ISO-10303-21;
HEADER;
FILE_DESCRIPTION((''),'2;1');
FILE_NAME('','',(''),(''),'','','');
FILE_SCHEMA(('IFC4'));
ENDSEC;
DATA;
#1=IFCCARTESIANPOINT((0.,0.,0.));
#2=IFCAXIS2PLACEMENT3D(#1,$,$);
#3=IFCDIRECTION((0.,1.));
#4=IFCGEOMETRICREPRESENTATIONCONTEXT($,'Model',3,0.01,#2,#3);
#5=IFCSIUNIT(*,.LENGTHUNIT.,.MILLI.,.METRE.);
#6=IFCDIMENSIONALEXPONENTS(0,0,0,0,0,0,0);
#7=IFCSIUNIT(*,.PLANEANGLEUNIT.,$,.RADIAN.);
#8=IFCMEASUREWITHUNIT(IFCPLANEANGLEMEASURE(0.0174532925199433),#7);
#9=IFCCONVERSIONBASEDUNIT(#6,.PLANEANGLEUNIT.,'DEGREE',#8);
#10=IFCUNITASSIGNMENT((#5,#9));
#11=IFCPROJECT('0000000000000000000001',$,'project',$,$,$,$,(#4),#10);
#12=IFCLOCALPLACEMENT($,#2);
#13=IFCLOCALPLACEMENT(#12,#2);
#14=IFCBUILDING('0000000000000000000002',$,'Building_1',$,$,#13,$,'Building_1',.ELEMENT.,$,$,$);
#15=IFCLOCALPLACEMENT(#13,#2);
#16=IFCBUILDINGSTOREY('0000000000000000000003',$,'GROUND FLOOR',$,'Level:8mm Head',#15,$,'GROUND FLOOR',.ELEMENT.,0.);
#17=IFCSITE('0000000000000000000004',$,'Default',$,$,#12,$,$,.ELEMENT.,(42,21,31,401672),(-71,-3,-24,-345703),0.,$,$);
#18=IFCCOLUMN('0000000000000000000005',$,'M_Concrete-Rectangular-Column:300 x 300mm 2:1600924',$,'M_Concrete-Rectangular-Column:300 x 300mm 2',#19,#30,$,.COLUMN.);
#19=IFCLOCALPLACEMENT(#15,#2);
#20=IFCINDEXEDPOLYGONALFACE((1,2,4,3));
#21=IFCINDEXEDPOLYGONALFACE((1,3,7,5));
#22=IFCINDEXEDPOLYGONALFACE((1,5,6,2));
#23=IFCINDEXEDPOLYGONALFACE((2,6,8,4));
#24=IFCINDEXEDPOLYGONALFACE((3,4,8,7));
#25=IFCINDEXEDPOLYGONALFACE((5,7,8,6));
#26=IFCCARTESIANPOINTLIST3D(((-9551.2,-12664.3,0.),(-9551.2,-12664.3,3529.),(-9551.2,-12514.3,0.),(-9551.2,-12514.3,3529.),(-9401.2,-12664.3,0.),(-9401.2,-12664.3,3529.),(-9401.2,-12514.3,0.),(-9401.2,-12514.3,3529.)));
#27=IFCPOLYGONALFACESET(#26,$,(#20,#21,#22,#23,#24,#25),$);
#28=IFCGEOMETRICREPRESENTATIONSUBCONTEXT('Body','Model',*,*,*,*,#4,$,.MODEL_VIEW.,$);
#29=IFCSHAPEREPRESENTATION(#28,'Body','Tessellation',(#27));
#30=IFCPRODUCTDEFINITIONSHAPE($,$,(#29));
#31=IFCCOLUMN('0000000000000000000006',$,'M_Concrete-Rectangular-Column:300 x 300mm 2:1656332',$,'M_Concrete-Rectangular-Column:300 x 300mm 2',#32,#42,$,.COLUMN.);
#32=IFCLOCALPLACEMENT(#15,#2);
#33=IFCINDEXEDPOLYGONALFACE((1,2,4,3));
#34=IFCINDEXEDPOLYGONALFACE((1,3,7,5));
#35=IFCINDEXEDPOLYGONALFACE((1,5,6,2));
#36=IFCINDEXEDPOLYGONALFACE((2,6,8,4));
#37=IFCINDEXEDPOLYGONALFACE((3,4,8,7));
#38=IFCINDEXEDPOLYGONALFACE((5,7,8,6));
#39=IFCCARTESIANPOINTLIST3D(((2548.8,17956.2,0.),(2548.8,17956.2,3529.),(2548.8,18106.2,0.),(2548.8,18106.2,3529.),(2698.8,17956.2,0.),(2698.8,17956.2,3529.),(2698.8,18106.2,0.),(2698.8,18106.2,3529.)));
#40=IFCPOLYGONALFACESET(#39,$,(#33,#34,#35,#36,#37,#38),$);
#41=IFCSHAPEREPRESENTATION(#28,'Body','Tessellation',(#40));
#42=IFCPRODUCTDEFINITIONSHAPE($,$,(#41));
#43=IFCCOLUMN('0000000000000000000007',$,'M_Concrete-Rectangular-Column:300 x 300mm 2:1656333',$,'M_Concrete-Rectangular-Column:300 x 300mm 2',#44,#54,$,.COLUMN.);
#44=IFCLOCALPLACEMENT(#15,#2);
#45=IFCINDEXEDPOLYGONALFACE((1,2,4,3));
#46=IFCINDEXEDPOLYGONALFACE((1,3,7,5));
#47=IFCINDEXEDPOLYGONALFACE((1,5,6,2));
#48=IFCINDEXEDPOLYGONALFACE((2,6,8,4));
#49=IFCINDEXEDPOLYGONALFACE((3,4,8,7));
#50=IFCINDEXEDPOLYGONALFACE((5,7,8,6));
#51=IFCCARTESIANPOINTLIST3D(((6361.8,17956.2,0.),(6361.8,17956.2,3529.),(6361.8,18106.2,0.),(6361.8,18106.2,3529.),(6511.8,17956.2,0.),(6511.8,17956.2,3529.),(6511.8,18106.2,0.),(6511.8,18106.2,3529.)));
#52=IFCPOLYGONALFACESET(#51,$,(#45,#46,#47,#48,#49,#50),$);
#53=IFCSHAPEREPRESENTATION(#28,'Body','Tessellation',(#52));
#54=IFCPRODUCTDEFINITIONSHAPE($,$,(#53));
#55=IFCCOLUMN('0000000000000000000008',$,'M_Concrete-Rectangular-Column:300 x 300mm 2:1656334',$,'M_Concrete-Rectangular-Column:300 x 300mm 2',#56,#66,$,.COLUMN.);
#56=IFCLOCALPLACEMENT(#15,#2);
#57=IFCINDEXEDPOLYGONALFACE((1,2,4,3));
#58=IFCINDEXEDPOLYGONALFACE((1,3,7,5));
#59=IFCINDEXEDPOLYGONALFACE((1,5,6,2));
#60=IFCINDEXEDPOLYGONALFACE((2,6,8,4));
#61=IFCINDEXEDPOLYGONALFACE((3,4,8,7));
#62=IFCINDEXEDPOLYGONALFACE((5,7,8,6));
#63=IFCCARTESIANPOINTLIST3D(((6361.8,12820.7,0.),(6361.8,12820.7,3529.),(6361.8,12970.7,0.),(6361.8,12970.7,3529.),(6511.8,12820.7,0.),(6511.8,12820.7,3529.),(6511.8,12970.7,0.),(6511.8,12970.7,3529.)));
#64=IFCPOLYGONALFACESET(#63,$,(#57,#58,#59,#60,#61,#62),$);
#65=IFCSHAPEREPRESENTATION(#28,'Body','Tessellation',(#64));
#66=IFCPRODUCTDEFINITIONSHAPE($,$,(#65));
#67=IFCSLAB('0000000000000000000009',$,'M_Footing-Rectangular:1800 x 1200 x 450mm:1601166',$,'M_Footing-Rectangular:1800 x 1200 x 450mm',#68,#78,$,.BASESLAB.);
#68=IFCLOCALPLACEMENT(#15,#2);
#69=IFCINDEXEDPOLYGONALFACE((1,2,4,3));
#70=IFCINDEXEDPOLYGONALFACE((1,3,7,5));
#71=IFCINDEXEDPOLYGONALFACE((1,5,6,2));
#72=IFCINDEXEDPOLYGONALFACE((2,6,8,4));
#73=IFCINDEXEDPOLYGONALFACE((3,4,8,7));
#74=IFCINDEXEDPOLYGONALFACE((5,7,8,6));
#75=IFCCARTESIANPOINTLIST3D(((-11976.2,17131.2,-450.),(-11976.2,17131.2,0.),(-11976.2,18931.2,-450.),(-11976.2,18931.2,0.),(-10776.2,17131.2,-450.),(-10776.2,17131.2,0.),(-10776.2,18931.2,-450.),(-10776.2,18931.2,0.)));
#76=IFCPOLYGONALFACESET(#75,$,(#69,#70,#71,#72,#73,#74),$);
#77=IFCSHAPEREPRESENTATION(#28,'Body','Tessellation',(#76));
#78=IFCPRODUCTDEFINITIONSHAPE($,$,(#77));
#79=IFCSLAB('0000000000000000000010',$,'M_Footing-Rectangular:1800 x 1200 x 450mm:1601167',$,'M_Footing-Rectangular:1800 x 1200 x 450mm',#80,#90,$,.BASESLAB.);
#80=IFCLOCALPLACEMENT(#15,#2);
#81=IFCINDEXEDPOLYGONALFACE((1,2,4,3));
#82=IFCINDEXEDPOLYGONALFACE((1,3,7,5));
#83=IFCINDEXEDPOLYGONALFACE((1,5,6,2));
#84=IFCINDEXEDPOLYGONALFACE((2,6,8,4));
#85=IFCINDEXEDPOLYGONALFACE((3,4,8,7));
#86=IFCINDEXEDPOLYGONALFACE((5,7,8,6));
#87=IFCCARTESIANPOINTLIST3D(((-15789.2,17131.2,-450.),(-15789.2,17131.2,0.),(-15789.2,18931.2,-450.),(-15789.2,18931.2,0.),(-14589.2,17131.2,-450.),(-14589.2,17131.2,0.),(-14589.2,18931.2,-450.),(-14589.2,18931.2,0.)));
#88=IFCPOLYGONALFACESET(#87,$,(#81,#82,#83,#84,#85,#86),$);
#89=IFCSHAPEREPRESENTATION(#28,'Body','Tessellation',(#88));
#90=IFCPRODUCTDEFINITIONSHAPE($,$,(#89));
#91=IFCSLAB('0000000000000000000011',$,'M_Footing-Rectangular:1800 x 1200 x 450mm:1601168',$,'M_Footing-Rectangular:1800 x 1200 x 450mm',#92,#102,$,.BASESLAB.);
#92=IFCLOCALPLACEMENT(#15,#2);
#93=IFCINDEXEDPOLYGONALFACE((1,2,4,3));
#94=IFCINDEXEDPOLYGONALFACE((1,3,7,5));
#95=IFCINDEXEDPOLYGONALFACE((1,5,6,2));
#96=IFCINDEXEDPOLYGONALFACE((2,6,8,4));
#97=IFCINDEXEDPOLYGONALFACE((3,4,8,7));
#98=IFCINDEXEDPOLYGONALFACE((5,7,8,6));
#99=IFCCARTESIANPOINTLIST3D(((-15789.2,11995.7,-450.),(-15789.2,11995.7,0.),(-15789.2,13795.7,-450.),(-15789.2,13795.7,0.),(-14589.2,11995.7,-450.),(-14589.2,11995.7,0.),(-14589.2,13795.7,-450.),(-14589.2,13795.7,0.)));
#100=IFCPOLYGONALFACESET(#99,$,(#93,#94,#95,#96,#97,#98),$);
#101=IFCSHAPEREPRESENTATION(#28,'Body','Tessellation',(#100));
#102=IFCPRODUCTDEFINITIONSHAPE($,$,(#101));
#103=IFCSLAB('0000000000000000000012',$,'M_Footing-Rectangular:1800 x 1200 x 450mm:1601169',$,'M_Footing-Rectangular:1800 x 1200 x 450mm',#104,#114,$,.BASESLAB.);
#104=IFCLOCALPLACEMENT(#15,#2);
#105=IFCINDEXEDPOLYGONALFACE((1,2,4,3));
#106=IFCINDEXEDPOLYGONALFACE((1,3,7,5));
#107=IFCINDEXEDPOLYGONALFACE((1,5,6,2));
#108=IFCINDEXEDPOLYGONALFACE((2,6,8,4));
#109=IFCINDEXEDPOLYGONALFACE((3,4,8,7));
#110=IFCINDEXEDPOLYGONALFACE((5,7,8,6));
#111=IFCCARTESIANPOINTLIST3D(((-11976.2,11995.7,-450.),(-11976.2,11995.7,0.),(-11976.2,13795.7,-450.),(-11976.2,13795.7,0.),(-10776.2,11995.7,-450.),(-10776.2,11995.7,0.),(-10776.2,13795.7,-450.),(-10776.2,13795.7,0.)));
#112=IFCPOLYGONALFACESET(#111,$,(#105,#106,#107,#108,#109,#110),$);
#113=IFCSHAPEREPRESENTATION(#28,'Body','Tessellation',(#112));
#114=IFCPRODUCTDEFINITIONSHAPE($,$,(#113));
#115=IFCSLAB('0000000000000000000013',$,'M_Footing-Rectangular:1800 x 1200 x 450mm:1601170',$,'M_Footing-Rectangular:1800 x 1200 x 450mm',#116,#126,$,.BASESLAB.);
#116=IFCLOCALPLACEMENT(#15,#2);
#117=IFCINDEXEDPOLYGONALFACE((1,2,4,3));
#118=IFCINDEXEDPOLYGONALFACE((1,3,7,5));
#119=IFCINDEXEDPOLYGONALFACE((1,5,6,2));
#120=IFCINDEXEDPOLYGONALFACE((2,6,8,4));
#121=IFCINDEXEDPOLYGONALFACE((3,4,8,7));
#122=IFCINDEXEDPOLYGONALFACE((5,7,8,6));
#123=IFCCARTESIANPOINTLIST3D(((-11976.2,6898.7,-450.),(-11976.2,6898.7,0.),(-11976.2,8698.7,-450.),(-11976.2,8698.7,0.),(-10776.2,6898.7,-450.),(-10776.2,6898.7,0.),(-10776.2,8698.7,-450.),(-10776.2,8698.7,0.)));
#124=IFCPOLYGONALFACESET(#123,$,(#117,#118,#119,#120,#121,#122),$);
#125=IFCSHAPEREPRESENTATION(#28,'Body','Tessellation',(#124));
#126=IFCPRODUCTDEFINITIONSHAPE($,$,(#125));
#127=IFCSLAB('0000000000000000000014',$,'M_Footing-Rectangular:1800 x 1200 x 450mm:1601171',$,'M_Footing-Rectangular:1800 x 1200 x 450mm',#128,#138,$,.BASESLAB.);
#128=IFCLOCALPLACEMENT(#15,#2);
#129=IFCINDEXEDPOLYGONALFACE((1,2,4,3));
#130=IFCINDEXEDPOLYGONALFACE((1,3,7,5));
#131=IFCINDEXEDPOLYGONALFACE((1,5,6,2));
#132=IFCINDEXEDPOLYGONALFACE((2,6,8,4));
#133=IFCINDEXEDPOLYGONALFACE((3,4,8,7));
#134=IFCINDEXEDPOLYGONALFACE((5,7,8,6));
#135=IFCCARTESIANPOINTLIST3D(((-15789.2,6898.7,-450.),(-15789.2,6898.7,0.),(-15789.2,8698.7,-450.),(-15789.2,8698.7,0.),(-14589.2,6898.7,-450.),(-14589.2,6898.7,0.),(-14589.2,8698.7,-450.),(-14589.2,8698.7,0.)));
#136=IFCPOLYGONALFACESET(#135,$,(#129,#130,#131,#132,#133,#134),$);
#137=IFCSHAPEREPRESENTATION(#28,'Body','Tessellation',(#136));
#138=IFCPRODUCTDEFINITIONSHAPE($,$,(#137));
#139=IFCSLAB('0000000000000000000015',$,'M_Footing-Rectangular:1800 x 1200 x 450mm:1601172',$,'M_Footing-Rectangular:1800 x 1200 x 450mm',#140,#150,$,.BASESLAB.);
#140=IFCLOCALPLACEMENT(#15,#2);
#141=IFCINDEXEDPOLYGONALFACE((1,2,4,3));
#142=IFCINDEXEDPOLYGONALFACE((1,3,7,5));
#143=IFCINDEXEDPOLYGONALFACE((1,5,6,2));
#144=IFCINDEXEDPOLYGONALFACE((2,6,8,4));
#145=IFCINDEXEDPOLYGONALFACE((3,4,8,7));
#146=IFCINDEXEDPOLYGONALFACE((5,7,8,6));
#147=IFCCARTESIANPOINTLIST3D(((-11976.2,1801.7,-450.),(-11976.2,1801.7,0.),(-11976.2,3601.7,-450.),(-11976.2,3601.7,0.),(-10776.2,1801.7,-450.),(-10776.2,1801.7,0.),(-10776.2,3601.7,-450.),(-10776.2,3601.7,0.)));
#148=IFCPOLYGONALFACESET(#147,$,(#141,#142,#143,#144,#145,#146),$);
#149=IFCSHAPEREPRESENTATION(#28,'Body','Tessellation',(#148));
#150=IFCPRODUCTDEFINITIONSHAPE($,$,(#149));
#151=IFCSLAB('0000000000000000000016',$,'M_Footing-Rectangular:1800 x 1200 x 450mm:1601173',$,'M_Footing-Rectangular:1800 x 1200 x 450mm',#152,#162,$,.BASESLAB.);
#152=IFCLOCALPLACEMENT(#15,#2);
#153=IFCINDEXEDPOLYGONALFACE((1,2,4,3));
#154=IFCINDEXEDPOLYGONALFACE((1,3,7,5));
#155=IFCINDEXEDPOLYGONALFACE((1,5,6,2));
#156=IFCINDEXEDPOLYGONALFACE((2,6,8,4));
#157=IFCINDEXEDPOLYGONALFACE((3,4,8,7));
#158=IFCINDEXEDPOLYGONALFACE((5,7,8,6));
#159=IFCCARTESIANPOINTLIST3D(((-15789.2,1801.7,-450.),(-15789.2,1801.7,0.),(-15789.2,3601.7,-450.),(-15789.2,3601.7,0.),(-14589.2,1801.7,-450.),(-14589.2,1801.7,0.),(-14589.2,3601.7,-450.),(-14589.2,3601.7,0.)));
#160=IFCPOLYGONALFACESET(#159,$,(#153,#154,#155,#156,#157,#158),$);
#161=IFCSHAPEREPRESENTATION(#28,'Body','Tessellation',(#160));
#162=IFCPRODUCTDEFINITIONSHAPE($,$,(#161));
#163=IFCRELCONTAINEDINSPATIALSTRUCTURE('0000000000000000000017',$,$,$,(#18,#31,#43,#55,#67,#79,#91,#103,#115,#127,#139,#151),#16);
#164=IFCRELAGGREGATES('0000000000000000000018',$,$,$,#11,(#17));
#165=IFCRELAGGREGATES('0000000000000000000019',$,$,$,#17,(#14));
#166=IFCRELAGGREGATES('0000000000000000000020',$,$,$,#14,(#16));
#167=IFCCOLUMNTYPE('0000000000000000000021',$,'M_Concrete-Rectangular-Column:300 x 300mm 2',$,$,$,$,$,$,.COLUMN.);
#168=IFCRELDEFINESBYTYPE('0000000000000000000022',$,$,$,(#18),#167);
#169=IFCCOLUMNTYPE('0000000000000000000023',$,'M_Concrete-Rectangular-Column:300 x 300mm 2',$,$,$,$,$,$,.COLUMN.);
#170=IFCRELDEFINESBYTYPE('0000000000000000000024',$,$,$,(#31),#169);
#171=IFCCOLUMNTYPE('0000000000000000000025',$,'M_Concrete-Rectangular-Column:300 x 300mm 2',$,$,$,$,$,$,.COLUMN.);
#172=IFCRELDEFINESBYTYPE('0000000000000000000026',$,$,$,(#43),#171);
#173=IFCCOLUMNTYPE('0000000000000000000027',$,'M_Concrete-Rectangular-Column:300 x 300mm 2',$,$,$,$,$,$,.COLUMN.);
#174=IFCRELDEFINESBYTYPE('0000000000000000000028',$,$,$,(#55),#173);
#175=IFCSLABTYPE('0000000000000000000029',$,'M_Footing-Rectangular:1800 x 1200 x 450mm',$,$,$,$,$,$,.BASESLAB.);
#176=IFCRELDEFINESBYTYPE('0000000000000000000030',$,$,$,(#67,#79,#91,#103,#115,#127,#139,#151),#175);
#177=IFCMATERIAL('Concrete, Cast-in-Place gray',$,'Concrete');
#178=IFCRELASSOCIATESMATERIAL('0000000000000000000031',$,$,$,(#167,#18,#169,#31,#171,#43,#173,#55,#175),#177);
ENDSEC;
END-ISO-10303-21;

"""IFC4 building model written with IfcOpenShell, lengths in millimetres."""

from ifc_helpers import new_model, entity, si_unit, converted_unit, direction, frame, origin, place, context, subcontext, project, spatial, indexed_curve, outline, extrude, source, transform, mapped, material, type_object, type_shapes, element, save


model = new_model("IFC4")

# Units and contexts
model_context = context("Model", 3, precision=0.01, world=origin(), true_north=direction((0.0, 1.0)))
body_context = subcontext(model_context, "Body", "Model", "MODEL_VIEW")
ifc_project = project(units=[si_unit("LENGTHUNIT", "METRE", prefix="MILLI"), converted_unit("PLANEANGLEUNIT", "DEGREE", entity("IfcPlaneAngleMeasure", 0.0174532925199433), si_unit("PLANEANGLEUNIT", "RADIAN"), dimensions=[0, 0, 0, 0, 0, 0, 0])], contexts=[model_context])

# Site, building, storey
site_placement = place(None, origin())
site = spatial("IfcSite", under=ifc_project, at=site_placement, Name="Default", CompositionType="ELEMENT", RefLatitude=(42, 21, 31, 401672), RefLongitude=(-71, -3, -24, -345703), RefElevation=0.0)
building_placement = place(site_placement, origin())
building = spatial("IfcBuilding", under=site, at=building_placement, Name="Building_1", LongName="Building_1", CompositionType="ELEMENT")
storey_placement = place(building_placement, origin())
storey = spatial("IfcBuildingStorey", under=building, at=storey_placement, Name="GROUND FLOOR", ObjectType="Level:8mm Head", LongName="GROUND FLOOR", CompositionType="ELEMENT", Elevation=0.0)

# Columns
ifc_material_1 = material(Name="Concrete, Cast-in-Place gray", Category="Concrete")
column_type_1 = type_object("IfcColumnType", Name="M_Concrete-Rectangular-Column:300 x 300mm 2", PredefinedType="COLUMN", material=ifc_material_1)
shared_shape_1 = source(origin(), body_context, "Body", "SweptSolid", [
    extrude(outline(indexed_curve([(-75.0, -75.0), (75.0, -75.0), (75.0, 75.0), (-75.0, 75.0), (-75.0, -75.0)], self_intersect=False)), frame((-9476.2, -12589.3, 0.0), z_axis=(0.0, 0.0, 1.0), x_axis=(-1.0, 0.0, 0.0)), (0.0, 0.0, 1.0), 3529.0),
])
type_shapes(column_type_1, [shared_shape_1])
column_1_placement = place(storey_placement, origin())
element("IfcColumn", 1, at=column_1_placement, inside=storey, type_object=column_type_1, material=ifc_material_1, Name="M_Concrete-Rectangular-Column:300 x 300mm 2:1600924", ObjectType="M_Concrete-Rectangular-Column:300 x 300mm 2", PredefinedType="COLUMN", context=body_context, shape_type="MappedRepresentation", body=[
    mapped(shared_shape_1, transform((0.0, 0.0, 0.0), scale=1.0)),
])
column_type_2 = type_object("IfcColumnType", Name="M_Concrete-Rectangular-Column:300 x 300mm 2", PredefinedType="COLUMN", material=ifc_material_1)
shared_shape_2 = source(origin(), body_context, "Body", "SweptSolid", [
    extrude(outline(indexed_curve([(-75.0, -75.0), (75.0, -75.0), (75.0, 75.0), (-75.0, 75.0), (-75.0, -75.0)], self_intersect=False)), frame((2623.8, 18031.2, 0.0)), (0.0, 0.0, 1.0), 3529.0),
])
type_shapes(column_type_2, [shared_shape_2])
column_2_placement = place(storey_placement, origin())
element("IfcColumn", 2, at=column_2_placement, inside=storey, type_object=column_type_2, material=ifc_material_1, Name="M_Concrete-Rectangular-Column:300 x 300mm 2:1656332", ObjectType="M_Concrete-Rectangular-Column:300 x 300mm 2", PredefinedType="COLUMN", context=body_context, shape_type="MappedRepresentation", body=[
    mapped(shared_shape_2, transform((0.0, 0.0, 0.0), scale=1.0)),
])
column_type_3 = type_object("IfcColumnType", Name="M_Concrete-Rectangular-Column:300 x 300mm 2", PredefinedType="COLUMN", material=ifc_material_1)
shared_shape_3 = source(origin(), body_context, "Body", "SweptSolid", [
    extrude(outline(indexed_curve([(-75.0, -75.0), (75.0, -75.0), (75.0, 75.0), (-75.0, 75.0), (-75.0, -75.0)], self_intersect=False)), frame((6436.8, 18031.2, 0.0)), (0.0, 0.0, 1.0), 3529.0),
])
type_shapes(column_type_3, [shared_shape_3])
column_3_placement = place(storey_placement, origin())
element("IfcColumn", 3, at=column_3_placement, inside=storey, type_object=column_type_3, material=ifc_material_1, Name="M_Concrete-Rectangular-Column:300 x 300mm 2:1656333", ObjectType="M_Concrete-Rectangular-Column:300 x 300mm 2", PredefinedType="COLUMN", context=body_context, shape_type="MappedRepresentation", body=[
    mapped(shared_shape_3, transform((0.0, 0.0, 0.0), scale=1.0)),
])
column_type_4 = type_object("IfcColumnType", Name="M_Concrete-Rectangular-Column:300 x 300mm 2", PredefinedType="COLUMN", material=ifc_material_1)
shared_shape_4 = source(origin(), body_context, "Body", "SweptSolid", [
    extrude(outline(indexed_curve([(-75.0, -75.0), (75.0, -75.0), (75.0, 75.0), (-75.0, 75.0), (-75.0, -75.0)], self_intersect=False)), frame((6436.8, 12895.7, 0.0)), (0.0, 0.0, 1.0), 3529.0),
])
type_shapes(column_type_4, [shared_shape_4])
column_4_placement = place(storey_placement, origin())
element("IfcColumn", 4, at=column_4_placement, inside=storey, type_object=column_type_4, material=ifc_material_1, Name="M_Concrete-Rectangular-Column:300 x 300mm 2:1656334", ObjectType="M_Concrete-Rectangular-Column:300 x 300mm 2", PredefinedType="COLUMN", context=body_context, shape_type="MappedRepresentation", body=[
    mapped(shared_shape_4, transform((0.0, 0.0, 0.0), scale=1.0)),
])

# Slabs
slab_type_1 = type_object("IfcSlabType", Name="M_Footing-Rectangular:1800 x 1200 x 450mm", PredefinedType="BASESLAB", material=ifc_material_1)
slab_1_placement = place(storey_placement, origin())
element("IfcSlab", 5, at=slab_1_placement, inside=storey, type_object=slab_type_1, Name="M_Footing-Rectangular:1800 x 1200 x 450mm:1601166", ObjectType="M_Footing-Rectangular:1800 x 1200 x 450mm", PredefinedType="BASESLAB", context=body_context, shape_type="SweptSolid", body=[
    extrude(outline(indexed_curve([(-600.0, -900.0), (600.0, -900.0), (600.0, 900.0), (-600.0, 900.0), (-600.0, -900.0)], self_intersect=False)), frame((-11376.2, 18031.2, -450.0), z_axis=(0.0, 0.0, 1.0), x_axis=(-1.0, 0.0, 0.0)), (0.0, 0.0, 1.0), 450.0),
])
slab_2_placement = place(storey_placement, origin())
element("IfcSlab", 6, at=slab_2_placement, inside=storey, type_object=slab_type_1, Name="M_Footing-Rectangular:1800 x 1200 x 450mm:1601167", ObjectType="M_Footing-Rectangular:1800 x 1200 x 450mm", PredefinedType="BASESLAB", context=body_context, shape_type="SweptSolid", body=[
    extrude(outline(indexed_curve([(-600.0, -900.0), (600.0, -900.0), (600.0, 900.0), (-600.0, 900.0), (-600.0, -900.0)], self_intersect=False)), frame((-15189.2, 18031.2, -450.0), z_axis=(0.0, 0.0, 1.0), x_axis=(-1.0, 0.0, 0.0)), (0.0, 0.0, 1.0), 450.0),
])
slab_3_placement = place(storey_placement, origin())
element("IfcSlab", 7, at=slab_3_placement, inside=storey, type_object=slab_type_1, Name="M_Footing-Rectangular:1800 x 1200 x 450mm:1601168", ObjectType="M_Footing-Rectangular:1800 x 1200 x 450mm", PredefinedType="BASESLAB", context=body_context, shape_type="SweptSolid", body=[
    extrude(outline(indexed_curve([(-600.0, -900.0), (600.0, -900.0), (600.0, 900.0), (-600.0, 900.0), (-600.0, -900.0)], self_intersect=False)), frame((-15189.2, 12895.7, -450.0), z_axis=(0.0, 0.0, 1.0), x_axis=(-1.0, 0.0, 0.0)), (0.0, 0.0, 1.0), 450.0),
])
slab_4_placement = place(storey_placement, origin())
element("IfcSlab", 8, at=slab_4_placement, inside=storey, type_object=slab_type_1, Name="M_Footing-Rectangular:1800 x 1200 x 450mm:1601169", ObjectType="M_Footing-Rectangular:1800 x 1200 x 450mm", PredefinedType="BASESLAB", context=body_context, shape_type="SweptSolid", body=[
    extrude(outline(indexed_curve([(-600.0, -900.0), (600.0, -900.0), (600.0, 900.0), (-600.0, 900.0), (-600.0, -900.0)], self_intersect=False)), frame((-11376.2, 12895.7, -450.0), z_axis=(0.0, 0.0, 1.0), x_axis=(-1.0, 0.0, 0.0)), (0.0, 0.0, 1.0), 450.0),
])
slab_5_placement = place(storey_placement, origin())
element("IfcSlab", 9, at=slab_5_placement, inside=storey, type_object=slab_type_1, Name="M_Footing-Rectangular:1800 x 1200 x 450mm:1601170", ObjectType="M_Footing-Rectangular:1800 x 1200 x 450mm", PredefinedType="BASESLAB", context=body_context, shape_type="SweptSolid", body=[
    extrude(outline(indexed_curve([(-600.0, -900.0), (600.0, -900.0), (600.0, 900.0), (-600.0, 900.0), (-600.0, -900.0)], self_intersect=False)), frame((-11376.2, 7798.7, -450.0), z_axis=(0.0, 0.0, 1.0), x_axis=(-1.0, 0.0, 0.0)), (0.0, 0.0, 1.0), 450.0),
])
slab_6_placement = place(storey_placement, origin())
element("IfcSlab", 10, at=slab_6_placement, inside=storey, type_object=slab_type_1, Name="M_Footing-Rectangular:1800 x 1200 x 450mm:1601171", ObjectType="M_Footing-Rectangular:1800 x 1200 x 450mm", PredefinedType="BASESLAB", context=body_context, shape_type="SweptSolid", body=[
    extrude(outline(indexed_curve([(-600.0, -900.0), (600.0, -900.0), (600.0, 900.0), (-600.0, 900.0), (-600.0, -900.0)], self_intersect=False)), frame((-15189.2, 7798.7, -450.0), z_axis=(0.0, 0.0, 1.0), x_axis=(-1.0, 0.0, 0.0)), (0.0, 0.0, 1.0), 450.0),
])
slab_7_placement = place(storey_placement, origin())
element("IfcSlab", 11, at=slab_7_placement, inside=storey, type_object=slab_type_1, Name="M_Footing-Rectangular:1800 x 1200 x 450mm:1601172", ObjectType="M_Footing-Rectangular:1800 x 1200 x 450mm", PredefinedType="BASESLAB", context=body_context, shape_type="SweptSolid", body=[
    extrude(outline(indexed_curve([(-600.0, -900.0), (600.0, -900.0), (600.0, 900.0), (-600.0, 900.0), (-600.0, -900.0)], self_intersect=False)), frame((-11376.2, 2701.7, -450.0), z_axis=(0.0, 0.0, 1.0), x_axis=(-1.0, 0.0, 0.0)), (0.0, 0.0, 1.0), 450.0),
])
slab_8_placement = place(storey_placement, origin())
element("IfcSlab", 12, at=slab_8_placement, inside=storey, type_object=slab_type_1, Name="M_Footing-Rectangular:1800 x 1200 x 450mm:1601173", ObjectType="M_Footing-Rectangular:1800 x 1200 x 450mm", PredefinedType="BASESLAB", context=body_context, shape_type="SweptSolid", body=[
    extrude(outline(indexed_curve([(-600.0, -900.0), (600.0, -900.0), (600.0, 900.0), (-600.0, 900.0), (-600.0, -900.0)], self_intersect=False)), frame((-15189.2, 2701.7, -450.0), z_axis=(0.0, 0.0, 1.0), x_axis=(-1.0, 0.0, 0.0)), (0.0, 0.0, 1.0), 450.0),
])

save(model, "model.ifc")
